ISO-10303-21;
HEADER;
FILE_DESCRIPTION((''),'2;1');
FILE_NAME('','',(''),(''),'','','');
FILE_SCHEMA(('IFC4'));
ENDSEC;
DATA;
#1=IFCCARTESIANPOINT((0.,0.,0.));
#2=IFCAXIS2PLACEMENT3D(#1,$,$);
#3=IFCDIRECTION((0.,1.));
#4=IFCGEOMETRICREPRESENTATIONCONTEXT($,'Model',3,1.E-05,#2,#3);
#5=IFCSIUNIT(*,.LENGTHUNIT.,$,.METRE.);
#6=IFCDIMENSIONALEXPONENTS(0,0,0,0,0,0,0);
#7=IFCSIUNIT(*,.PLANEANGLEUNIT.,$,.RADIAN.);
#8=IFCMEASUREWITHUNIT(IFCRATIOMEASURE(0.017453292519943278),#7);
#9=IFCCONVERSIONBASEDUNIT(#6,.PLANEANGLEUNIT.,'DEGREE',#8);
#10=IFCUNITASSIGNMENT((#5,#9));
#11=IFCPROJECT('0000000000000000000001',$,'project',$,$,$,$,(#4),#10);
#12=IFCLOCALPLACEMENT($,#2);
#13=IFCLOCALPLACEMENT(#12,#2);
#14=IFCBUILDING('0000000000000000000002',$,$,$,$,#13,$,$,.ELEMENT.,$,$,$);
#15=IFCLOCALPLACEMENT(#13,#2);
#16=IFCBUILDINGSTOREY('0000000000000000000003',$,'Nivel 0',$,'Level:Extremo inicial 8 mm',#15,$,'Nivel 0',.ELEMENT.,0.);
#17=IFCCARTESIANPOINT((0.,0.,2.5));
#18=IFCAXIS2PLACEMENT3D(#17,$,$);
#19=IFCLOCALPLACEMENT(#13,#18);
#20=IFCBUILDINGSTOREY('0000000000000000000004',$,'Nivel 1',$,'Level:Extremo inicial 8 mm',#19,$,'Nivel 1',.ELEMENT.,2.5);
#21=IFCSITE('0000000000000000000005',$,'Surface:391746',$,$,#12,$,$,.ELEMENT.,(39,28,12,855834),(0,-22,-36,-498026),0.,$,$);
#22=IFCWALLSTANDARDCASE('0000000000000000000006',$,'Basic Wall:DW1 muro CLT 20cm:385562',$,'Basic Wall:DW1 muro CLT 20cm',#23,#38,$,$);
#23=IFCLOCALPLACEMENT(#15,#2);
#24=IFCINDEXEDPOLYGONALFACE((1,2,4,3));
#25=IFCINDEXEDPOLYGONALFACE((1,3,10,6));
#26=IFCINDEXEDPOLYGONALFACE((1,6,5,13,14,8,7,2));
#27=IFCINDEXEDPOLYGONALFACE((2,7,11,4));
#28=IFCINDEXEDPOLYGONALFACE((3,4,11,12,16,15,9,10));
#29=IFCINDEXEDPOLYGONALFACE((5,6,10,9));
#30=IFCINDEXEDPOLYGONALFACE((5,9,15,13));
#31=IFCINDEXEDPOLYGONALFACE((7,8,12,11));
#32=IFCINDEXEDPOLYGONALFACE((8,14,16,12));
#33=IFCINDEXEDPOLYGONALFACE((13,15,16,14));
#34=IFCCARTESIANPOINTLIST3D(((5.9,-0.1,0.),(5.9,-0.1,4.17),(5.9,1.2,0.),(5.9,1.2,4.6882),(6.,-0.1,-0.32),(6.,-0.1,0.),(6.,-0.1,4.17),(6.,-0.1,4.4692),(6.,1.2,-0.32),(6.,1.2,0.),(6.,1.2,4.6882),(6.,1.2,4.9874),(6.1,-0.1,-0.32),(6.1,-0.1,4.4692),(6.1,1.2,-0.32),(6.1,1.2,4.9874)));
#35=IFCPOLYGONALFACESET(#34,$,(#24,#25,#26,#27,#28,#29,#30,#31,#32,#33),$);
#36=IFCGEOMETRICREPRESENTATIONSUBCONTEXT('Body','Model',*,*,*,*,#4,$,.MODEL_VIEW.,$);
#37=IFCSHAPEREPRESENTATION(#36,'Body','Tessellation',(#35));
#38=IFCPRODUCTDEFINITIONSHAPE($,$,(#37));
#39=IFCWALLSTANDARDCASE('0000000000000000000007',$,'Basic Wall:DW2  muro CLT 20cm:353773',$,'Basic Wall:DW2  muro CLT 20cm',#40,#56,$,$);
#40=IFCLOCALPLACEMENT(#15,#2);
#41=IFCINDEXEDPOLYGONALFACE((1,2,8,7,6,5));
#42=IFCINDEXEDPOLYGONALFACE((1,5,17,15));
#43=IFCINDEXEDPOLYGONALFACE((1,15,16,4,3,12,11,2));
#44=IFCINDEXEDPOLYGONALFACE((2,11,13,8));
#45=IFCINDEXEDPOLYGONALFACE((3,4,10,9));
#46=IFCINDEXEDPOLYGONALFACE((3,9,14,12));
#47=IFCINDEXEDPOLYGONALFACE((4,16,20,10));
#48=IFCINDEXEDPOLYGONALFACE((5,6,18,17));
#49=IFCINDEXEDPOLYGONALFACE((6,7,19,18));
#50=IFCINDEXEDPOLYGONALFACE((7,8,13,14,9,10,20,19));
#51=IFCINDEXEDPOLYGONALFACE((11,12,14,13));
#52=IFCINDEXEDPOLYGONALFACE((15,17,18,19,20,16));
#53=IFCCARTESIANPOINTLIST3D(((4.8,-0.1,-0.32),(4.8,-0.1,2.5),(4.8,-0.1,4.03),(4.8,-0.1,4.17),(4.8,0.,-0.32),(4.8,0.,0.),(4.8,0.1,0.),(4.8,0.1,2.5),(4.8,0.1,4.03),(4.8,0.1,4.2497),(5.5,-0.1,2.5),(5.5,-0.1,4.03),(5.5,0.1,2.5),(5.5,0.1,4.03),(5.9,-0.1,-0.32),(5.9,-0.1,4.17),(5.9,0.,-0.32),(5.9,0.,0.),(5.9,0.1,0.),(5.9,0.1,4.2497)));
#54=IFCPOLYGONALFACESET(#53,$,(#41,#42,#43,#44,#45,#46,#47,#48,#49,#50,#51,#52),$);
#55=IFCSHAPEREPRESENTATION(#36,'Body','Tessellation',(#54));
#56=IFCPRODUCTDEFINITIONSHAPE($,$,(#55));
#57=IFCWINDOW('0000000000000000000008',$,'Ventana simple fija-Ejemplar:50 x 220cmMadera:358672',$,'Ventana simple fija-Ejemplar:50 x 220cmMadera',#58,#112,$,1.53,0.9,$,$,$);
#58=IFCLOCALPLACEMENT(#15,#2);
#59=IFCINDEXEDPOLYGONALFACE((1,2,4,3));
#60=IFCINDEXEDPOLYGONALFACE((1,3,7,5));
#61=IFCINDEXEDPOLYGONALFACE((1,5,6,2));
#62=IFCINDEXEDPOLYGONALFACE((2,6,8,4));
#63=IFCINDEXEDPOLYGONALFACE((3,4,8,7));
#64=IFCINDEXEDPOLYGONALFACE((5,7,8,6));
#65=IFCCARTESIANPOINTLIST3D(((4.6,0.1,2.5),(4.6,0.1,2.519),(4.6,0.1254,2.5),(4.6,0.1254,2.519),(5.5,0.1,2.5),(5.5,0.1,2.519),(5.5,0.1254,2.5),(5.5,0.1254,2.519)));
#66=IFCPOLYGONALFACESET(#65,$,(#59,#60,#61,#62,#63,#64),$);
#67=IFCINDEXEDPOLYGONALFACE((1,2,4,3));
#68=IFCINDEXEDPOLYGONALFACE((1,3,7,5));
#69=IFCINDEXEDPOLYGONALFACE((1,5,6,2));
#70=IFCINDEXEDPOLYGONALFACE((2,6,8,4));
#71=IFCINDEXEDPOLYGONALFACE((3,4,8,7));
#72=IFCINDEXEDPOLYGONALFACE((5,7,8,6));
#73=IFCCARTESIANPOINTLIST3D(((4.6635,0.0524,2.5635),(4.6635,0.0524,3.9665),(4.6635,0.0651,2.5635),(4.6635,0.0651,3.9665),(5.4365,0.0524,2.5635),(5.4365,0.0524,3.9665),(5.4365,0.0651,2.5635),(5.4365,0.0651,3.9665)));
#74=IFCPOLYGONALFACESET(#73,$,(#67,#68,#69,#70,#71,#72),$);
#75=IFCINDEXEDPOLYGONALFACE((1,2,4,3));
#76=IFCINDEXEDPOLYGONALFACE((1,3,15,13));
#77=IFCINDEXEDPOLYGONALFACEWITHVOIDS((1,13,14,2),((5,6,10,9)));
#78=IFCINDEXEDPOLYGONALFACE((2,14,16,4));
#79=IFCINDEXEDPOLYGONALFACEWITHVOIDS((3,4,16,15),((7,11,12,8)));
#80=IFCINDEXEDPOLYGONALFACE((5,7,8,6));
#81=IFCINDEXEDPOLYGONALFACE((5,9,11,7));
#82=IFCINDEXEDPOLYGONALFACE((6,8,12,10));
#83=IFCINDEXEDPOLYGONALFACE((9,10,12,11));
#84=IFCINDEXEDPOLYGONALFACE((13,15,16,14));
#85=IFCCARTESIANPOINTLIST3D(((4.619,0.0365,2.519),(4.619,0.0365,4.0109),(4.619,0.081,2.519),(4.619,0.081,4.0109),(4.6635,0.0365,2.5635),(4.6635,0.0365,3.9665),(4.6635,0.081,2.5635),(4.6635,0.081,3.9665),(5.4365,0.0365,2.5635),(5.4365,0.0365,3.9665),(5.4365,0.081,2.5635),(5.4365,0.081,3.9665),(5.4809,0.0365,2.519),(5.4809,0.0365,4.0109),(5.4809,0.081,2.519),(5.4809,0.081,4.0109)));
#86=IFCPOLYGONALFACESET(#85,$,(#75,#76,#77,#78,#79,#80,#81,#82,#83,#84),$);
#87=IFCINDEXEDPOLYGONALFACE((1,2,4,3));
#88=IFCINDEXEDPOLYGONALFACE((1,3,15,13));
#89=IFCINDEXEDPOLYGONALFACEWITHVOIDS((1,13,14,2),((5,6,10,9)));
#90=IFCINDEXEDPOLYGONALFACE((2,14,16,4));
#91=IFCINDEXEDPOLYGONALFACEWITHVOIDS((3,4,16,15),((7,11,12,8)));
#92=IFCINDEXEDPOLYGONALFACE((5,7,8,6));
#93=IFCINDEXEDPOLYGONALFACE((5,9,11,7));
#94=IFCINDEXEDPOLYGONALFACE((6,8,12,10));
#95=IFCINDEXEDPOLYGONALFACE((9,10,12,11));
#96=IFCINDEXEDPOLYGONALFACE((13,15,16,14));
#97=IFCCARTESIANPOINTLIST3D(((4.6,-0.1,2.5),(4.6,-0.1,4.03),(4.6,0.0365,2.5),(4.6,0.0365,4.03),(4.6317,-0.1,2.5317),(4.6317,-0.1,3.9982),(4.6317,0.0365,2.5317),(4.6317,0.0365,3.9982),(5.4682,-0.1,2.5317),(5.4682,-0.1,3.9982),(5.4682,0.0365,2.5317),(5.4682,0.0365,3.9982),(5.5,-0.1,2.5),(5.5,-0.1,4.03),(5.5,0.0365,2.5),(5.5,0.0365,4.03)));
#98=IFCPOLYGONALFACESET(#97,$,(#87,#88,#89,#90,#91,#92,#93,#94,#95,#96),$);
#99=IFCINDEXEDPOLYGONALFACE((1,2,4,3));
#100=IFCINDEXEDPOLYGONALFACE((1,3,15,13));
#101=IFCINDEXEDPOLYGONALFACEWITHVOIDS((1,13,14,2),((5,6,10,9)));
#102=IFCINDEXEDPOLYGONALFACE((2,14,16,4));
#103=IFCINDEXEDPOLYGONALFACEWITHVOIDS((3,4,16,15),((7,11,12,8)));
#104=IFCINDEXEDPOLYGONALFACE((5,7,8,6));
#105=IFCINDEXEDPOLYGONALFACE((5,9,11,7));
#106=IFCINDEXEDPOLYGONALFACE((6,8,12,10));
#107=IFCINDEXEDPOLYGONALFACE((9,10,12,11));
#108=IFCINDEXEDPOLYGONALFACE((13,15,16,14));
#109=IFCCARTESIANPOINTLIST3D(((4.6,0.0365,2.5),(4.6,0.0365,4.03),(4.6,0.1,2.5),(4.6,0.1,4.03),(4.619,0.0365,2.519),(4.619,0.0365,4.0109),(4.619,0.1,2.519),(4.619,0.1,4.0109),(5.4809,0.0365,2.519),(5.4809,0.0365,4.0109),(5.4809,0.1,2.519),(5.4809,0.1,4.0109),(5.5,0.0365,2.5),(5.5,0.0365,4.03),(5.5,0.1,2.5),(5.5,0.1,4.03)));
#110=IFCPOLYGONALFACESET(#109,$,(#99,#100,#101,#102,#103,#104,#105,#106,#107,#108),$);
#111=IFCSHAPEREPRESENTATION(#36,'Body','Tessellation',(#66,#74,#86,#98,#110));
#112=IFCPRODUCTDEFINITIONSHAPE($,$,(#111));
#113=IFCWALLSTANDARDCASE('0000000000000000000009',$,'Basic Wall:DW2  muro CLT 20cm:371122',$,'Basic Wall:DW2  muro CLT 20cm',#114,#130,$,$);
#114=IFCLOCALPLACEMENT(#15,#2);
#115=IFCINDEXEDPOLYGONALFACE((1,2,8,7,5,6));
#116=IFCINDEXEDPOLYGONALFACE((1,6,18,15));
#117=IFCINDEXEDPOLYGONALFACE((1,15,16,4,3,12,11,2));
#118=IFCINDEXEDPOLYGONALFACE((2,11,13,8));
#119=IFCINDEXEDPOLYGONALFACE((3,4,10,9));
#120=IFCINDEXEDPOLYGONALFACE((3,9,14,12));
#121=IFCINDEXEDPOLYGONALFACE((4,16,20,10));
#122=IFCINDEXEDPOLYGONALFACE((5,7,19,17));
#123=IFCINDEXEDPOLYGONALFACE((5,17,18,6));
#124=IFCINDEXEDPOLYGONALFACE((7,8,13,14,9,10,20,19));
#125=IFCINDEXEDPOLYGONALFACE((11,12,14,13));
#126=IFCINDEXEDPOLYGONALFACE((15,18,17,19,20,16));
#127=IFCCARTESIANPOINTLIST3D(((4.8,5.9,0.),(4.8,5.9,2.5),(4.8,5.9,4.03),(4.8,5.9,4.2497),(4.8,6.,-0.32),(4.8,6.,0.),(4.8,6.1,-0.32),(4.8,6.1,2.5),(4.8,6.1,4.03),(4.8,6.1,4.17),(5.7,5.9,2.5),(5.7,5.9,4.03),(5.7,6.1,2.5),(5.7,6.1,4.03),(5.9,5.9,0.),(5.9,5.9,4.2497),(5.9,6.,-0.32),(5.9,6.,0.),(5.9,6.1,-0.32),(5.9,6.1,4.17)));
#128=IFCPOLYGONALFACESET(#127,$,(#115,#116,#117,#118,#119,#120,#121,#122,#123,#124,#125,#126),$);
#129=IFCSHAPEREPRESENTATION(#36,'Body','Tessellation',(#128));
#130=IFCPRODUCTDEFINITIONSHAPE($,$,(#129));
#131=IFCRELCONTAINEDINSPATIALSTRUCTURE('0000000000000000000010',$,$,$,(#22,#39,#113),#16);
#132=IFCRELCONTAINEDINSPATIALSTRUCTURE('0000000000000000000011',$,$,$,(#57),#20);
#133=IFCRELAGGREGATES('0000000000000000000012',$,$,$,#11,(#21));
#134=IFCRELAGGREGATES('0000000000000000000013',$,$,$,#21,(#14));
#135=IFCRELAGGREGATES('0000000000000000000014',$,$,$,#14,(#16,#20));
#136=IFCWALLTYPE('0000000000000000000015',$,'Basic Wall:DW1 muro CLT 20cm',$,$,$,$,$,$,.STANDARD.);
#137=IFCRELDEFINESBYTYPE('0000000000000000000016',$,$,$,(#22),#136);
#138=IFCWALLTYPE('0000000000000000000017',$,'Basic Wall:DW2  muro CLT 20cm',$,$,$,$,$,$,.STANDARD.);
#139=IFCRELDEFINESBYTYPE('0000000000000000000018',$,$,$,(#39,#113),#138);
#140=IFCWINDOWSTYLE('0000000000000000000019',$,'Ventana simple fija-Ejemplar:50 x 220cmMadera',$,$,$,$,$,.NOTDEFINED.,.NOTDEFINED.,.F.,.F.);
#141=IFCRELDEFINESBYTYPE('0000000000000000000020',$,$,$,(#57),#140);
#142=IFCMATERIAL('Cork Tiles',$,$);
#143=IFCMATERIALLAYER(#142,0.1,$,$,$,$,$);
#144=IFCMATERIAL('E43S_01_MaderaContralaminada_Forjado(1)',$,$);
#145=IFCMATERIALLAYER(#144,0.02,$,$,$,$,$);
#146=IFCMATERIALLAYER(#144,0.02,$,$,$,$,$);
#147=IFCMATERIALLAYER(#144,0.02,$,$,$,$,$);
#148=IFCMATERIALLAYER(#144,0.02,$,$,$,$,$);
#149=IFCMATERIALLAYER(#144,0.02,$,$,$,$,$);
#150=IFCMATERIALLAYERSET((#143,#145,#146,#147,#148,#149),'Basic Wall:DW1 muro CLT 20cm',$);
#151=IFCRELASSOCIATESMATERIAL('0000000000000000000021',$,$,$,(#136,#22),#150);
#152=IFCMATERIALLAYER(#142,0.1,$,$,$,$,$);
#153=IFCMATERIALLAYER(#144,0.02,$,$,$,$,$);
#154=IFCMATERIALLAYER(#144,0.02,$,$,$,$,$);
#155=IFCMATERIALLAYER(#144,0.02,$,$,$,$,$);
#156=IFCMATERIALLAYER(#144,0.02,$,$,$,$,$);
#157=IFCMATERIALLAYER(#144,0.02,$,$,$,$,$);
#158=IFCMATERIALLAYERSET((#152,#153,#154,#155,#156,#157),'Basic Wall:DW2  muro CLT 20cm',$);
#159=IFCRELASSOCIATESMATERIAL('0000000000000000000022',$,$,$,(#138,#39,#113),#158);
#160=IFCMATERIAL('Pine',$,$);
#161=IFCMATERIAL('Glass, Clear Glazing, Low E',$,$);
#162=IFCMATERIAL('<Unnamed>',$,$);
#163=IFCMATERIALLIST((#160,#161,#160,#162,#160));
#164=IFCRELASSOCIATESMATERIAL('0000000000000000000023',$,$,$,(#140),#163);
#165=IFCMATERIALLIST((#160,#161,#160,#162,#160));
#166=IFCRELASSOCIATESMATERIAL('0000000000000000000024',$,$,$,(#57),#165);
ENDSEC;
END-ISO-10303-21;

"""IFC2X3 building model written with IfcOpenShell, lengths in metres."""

from ifc_helpers import new_model, entity, si_unit, converted_unit, direction, frame, frame_2d, origin, origin_2d_with_axis, place, context, subcontext, project, spatial, polyline, rectangle, outline, extrude, clip, bounded_halfspace, source, transform, mapped, material, material_list, layer, layer_set, layer_usage, type_object, type_shapes, element, fill, save


model = new_model("IFC2X3")

# Units and contexts
model_context = context("Model", 3, precision=1e-05, world=origin(), true_north=direction((0.0, 1.0)))
body_context = subcontext(model_context, "Body", "Model", "MODEL_VIEW")
ifc_project = project(units=[si_unit("LENGTHUNIT", "METRE"), converted_unit("PLANEANGLEUNIT", "DEGREE", entity("IfcRatioMeasure", 0.017453292519943278), si_unit("PLANEANGLEUNIT", "RADIAN"), dimensions=[0, 0, 0, 0, 0, 0, 0])], contexts=[model_context])

# Site, building, storey
site_placement = place(None, origin())
site = spatial("IfcSite", under=ifc_project, at=site_placement, Name="Surface:391746", CompositionType="ELEMENT", RefLatitude=(39, 28, 12, 855834), RefLongitude=(0, -22, -36, -498026), RefElevation=0.0)
building_placement = place(site_placement, origin())
building = spatial("IfcBuilding", under=site, at=building_placement, CompositionType="ELEMENT")
storey_1_placement = place(building_placement, origin())
storey_1 = spatial("IfcBuildingStorey", under=building, at=storey_1_placement, Name="Nivel 0", ObjectType="Level:Extremo inicial 8 mm", LongName="Nivel 0", CompositionType="ELEMENT", Elevation=0.0)

# Shared definitions
ifc_material_1 = material(Name="E43S_01_MaderaContralaminada_Forjado(1)")

# Wall
ifc_material_2 = material(Name="Cork Tiles")
ifc_layer_1 = layer(ifc_material_2, 0.1)
ifc_layer_2 = layer(ifc_material_1, 0.02)
ifc_layer_3 = layer(ifc_material_1, 0.02)
ifc_layer_4 = layer(ifc_material_1, 0.02)
ifc_layer_5 = layer(ifc_material_1, 0.02)
ifc_layer_6 = layer(ifc_material_1, 0.02)
ifc_layer_set_1 = layer_set([ifc_layer_1, ifc_layer_2, ifc_layer_3, ifc_layer_4, ifc_layer_5, ifc_layer_6], Name="Basic Wall:DW1 muro CLT 20cm")
wall_type_1 = type_object("IfcWallType", Name="Basic Wall:DW1 muro CLT 20cm", PredefinedType="STANDARD", material=ifc_layer_set_1)
ifc_layer_usage_1 = layer_usage(ifc_layer_set_1, "AXIS2", "NEGATIVE", 0.1)
wall_1_placement = place(storey_1_placement, frame((6.0, 1.2, -0.32), z_axis=(0.0, 0.0, 1.0), x_axis=(0.0, -1.0, 0.0)))
element("IfcWallStandardCase", 1, at=wall_1_placement, inside=storey_1, type_object=wall_type_1, material=ifc_layer_usage_1, Name="Basic Wall:DW1 muro CLT 20cm:385562", ObjectType="Basic Wall:DW1 muro CLT 20cm", context=body_context, shape_type="Clipping", body=[
    clip(clip(clip(extrude(rectangle(XDim=1.3, YDim=0.2, at=frame_2d((0.65, 0.0), x_axis=(-1.0, 0.0))), origin(), (0.0, 0.0, 1.0), 5.3074), bounded_halfspace(frame((0.0, -0.1, 5.0082), z_axis=(0.370288, 0.0, 0.928917), x_axis=(0.0, 1.0, 0.0)), False, frame((0.0, -0.1, 5.0082)), polyline([(0.0, 0.0), (1.1, 0.0), (1.3, 0.0), (1.3, 0.1), (0.0, 0.1), (0.0, 0.0)]))), bounded_halfspace(frame((1.3, 0.0, 4.7892), z_axis=(0.370288, 0.0, 0.928917), x_axis=(0.0, 1.0, 0.0)), False, frame((1.3, 0.0, 4.7892)), polyline([(0.0, 0.0), (0.0, 0.1), (-1.3, 0.1), (-1.3, 0.0), (0.0, 0.0)]))), bounded_halfspace(frame((1.3, -0.1, 0.32), z_axis=(0.0, 0.0, -1.0), x_axis=(0.0, 1.0, 0.0)), False, frame((1.3, -0.1, 0.32)), polyline([(0.0, 0.0), (0.0, 0.1), (-1.3, 0.1), (-1.3, 0.0), (-0.2, 0.0), (-0.1, 0.0), (0.0, 0.0)]))),
])

# Wall, openings
ifc_layer_7 = layer(ifc_material_2, 0.1)
ifc_layer_8 = layer(ifc_material_1, 0.02)
ifc_layer_9 = layer(ifc_material_1, 0.02)
ifc_layer_10 = layer(ifc_material_1, 0.02)
ifc_layer_11 = layer(ifc_material_1, 0.02)
ifc_layer_12 = layer(ifc_material_1, 0.02)
ifc_layer_set_2 = layer_set([ifc_layer_7, ifc_layer_8, ifc_layer_9, ifc_layer_10, ifc_layer_11, ifc_layer_12], Name="Basic Wall:DW2  muro CLT 20cm")
ifc_layer_usage_2 = layer_usage(ifc_layer_set_2, "AXIS2", "NEGATIVE", 0.1)
wall_type_2 = type_object("IfcWallType", Name="Basic Wall:DW2  muro CLT 20cm", PredefinedType="STANDARD", material=ifc_layer_set_2)
wall_2_placement = place(storey_1_placement, frame((5.9, 0.0, -0.32), z_axis=(0.0, 0.0, 1.0), x_axis=(-1.0, 0.0, 0.0)))
wall_2 = element("IfcWallStandardCase", 2, at=wall_2_placement, inside=storey_1, type_object=wall_type_2, material=ifc_layer_usage_2, Name="Basic Wall:DW2  muro CLT 20cm:353773", ObjectType="Basic Wall:DW2  muro CLT 20cm", context=body_context, shape_type="Clipping", body=[
    clip(clip(clip(extrude(rectangle(XDim=1.1, YDim=0.2, at=frame_2d((0.55, 0.0), x_axis=(-1.0, 0.0))), origin(), (0.0, 0.0, 1.0), 4.5697), bounded_halfspace(frame((0.0, -0.1, 4.5697), z_axis=(0.0, 0.370288, 0.928917), x_axis=(-1.0, 0.0, 0.0)), False, frame((0.0, -0.1, 4.5697)), polyline([(0.0, 0.0), (1.04, 0.0), (1.04, 0.2), (0.0, 0.2), (0.0, 0.0)]))), bounded_halfspace(frame((1.04, -0.1, 4.5697), z_axis=(0.0, 0.370288, 0.928917), x_axis=(-1.0, 0.0, 0.0)), False, frame((1.04, -0.1, 4.5697)), polyline([(0.0, 0.0), (0.06, 0.0), (0.06, 0.2), (0.0, 0.2), (0.0, 0.0)]))), bounded_halfspace(frame((1.1, -0.1, 0.32), z_axis=(0.0, 0.0, -1.0), x_axis=(0.0, 1.0, 0.0)), False, frame((1.1, -0.1, 0.32)), polyline([(0.0, 0.0), (0.0, 0.1), (-1.1, 0.1), (-1.1, 0.0), (0.0, 0.0)]))),
])
opening_1_placement = place(wall_2_placement, origin())
element("IfcOpeningElement", 3, at=opening_1_placement, cuts=wall_2, ObjectType="Opening", context=body_context, shape_type="SweptSolid", body=[
    extrude(rectangle(XDim=2.1, YDim=1.4, at=origin_2d_with_axis()), frame((4.7, -1.424, 1.37), z_axis=(0.0, 1.0, 0.0), x_axis=(0.0, 0.0, -1.0)), (0.0, 0.0, 1.0), 3.048),
])
opening_2_placement = place(wall_2_placement, frame((1.3, 0.1, 2.82)))
opening_2 = element("IfcOpeningElement", 4, at=opening_2_placement, cuts=wall_2, ObjectType="Opening", context=body_context, shape_type="SweptSolid", body=[
    extrude(rectangle(XDim=1.53, YDim=0.9, at=frame_2d((0.765, 0.45), x_axis=(-1.0, 0.0))), frame((0.0, 0.0, 0.0), z_axis=(0.0, -1.0, 0.0), x_axis=(0.0, 0.0, 1.0)), (0.0, 0.0, 1.0), 0.2),
])

# Shared definitions
storey_2_placement = place(building_placement, frame((0.0, 0.0, 2.5)))
storey_2 = spatial("IfcBuildingStorey", under=building, at=storey_2_placement, Name="Nivel 1", ObjectType="Level:Extremo inicial 8 mm", LongName="Nivel 1", CompositionType="ELEMENT", Elevation=2.5)

# Window
ifc_material_3 = material(Name="Pine")
ifc_material_4 = material(Name="Glass, Clear Glazing, Low E")
ifc_material_5 = material(Name="<Unnamed>")
ifc_material_list_1 = material_list([ifc_material_3, ifc_material_4, ifc_material_3, ifc_material_5, ifc_material_3])
ifc_material_list_2 = material_list([ifc_material_3, ifc_material_4, ifc_material_3, ifc_material_5, ifc_material_3])
window_style = type_object("IfcWindowStyle", Name="Ventana simple fija-Ejemplar:50 x 220cmMadera", ConstructionType="NOTDEFINED", OperationType="NOTDEFINED", ParameterTakesPrecedence=False, Sizeable=False, material=ifc_material_list_2)
shared_shape_1 = source(origin(), body_context, "Body", "SweptSolid", [
    extrude(rectangle(XDim=0.9, YDim=0.0254, at=origin_2d_with_axis()), frame((0.5262, 0.2127, 0.0), z_axis=(0.0, 0.0, 1.0), x_axis=(-1.0, 0.0, 0.0)), (0.0, 0.0, 1.0), 0.019),
    extrude(rectangle(XDim=0.773, YDim=0.0127, at=frame_2d((0.0, 0.0), x_axis=(1.0, 0.0))), frame((0.5262, 0.1588, 0.0635)), (0.0, 0.0, 1.0), 1.403),
    extrude(outline(polyline([(-0.431, -0.7459), (0.431, -0.7459), (0.431, 0.7459), (-0.431, 0.7459), (-0.431, -0.7459)]), holes=[polyline([(-0.3865, -0.7015), (-0.3865, 0.7015), (0.3865, 0.7015), (0.3865, -0.7015), (-0.3865, -0.7015)])]), frame((0.5262, 0.181, 0.765), z_axis=(0.0, -1.0, 0.0), x_axis=(-1.0, 0.0, 0.0)), (0.0, 0.0, 1.0), 0.0444),
    extrude(outline(polyline([(-0.45, -0.765), (0.45, -0.765), (0.45, 0.765), (-0.45, 0.765), (-0.45, -0.765)]), holes=[polyline([(-0.4183, -0.7332), (-0.4183, 0.7332), (0.4183, 0.7332), (0.4183, -0.7332), (-0.4183, -0.7332)])]), frame((0.5262, 0.1365, 0.765), z_axis=(0.0, -1.0, 0.0), x_axis=(-1.0, 0.0, 0.0)), (0.0, 0.0, 1.0), 0.1365),
    extrude(outline(polyline([(-0.765, -0.45), (0.765, -0.45), (0.765, 0.45), (-0.765, 0.45), (-0.765, -0.45)]), holes=[polyline([(-0.7459, -0.431), (-0.7459, 0.431), (0.7459, 0.431), (0.7459, -0.431), (-0.7459, -0.431)])]), frame((0.5262, 0.2, 0.765), z_axis=(0.0, -1.0, 0.0), x_axis=(0.0, 0.0, -1.0)), (0.0, 0.0, 1.0), 0.0635),
])
type_shapes(window_style, [shared_shape_1])
window_placement = place(opening_2_placement, frame((0.0762, 0.0, 0.0), z_axis=(0.0, 0.0, 1.0), x_axis=(-1.0, 0.0, 0.0)))
window = element("IfcWindow", 5, at=window_placement, inside=storey_2, type_object=window_style, material=ifc_material_list_1, Name="Ventana simple fija-Ejemplar:50 x 220cmMadera:358672", ObjectType="Ventana simple fija-Ejemplar:50 x 220cmMadera", OverallHeight=1.53, OverallWidth=0.9, context=body_context, shape_type="MappedRepresentation", body=[
    mapped(shared_shape_1, transform((0.0, 0.0, 0.0), scale=1.0)),
])
fill(opening_2, window)

# Wall, openings
ifc_layer_usage_3 = layer_usage(ifc_layer_set_2, "AXIS2", "NEGATIVE", 0.1)
wall_3_placement = place(storey_1_placement, frame((4.8, 6.0, -0.32)))
wall_3 = element("IfcWallStandardCase", 6, at=wall_3_placement, inside=storey_1, type_object=wall_type_2, material=ifc_layer_usage_3, Name="Basic Wall:DW2  muro CLT 20cm:371122", ObjectType="Basic Wall:DW2  muro CLT 20cm", context=body_context, shape_type="Clipping", body=[
    clip(clip(clip(extrude(rectangle(XDim=1.1, YDim=0.2, at=frame_2d((0.55, 0.0), x_axis=(-1.0, 0.0))), origin(), (0.0, 0.0, 1.0), 4.5697), bounded_halfspace(frame((0.0, -0.1, 4.5697), z_axis=(0.0, 0.370288, 0.928917), x_axis=(-1.0, 0.0, 0.0)), False, frame((0.0, -0.1, 4.5697)), polyline([(0.0, 0.0), (0.06, 0.0), (0.06, 0.2), (0.0, 0.2), (0.0, 0.0)]))), bounded_halfspace(frame((1.1, -0.1, 4.5697), z_axis=(0.0, 0.370288, 0.928917), x_axis=(-1.0, 0.0, 0.0)), False, frame((1.1, -0.1, 4.5697)), polyline([(0.0, 0.0), (0.0, 0.2), (-1.04, 0.2), (-1.04, 0.0), (0.0, 0.0)]))), bounded_halfspace(frame((1.1, -0.1, 0.32), z_axis=(0.0, 0.0, -1.0), x_axis=(0.0, 1.0, 0.0)), False, frame((1.1, -0.1, 0.32)), polyline([(0.0, 0.0), (0.0, 0.1), (-1.1, 0.1), (-1.1, 0.0), (0.0, 0.0)]))),
])
opening_3_placement = place(wall_3_placement, origin())
element("IfcOpeningElement", 7, at=opening_3_placement, cuts=wall_3, ObjectType="Opening", context=body_context, shape_type="SweptSolid", body=[
    extrude(rectangle(XDim=1.53, YDim=0.9, at=frame_2d((0.0, 0.0), x_axis=(1.0, 0.0))), frame((0.45, -1.378, 3.585), z_axis=(0.0, 1.0, 0.0), x_axis=(0.0, 0.0, -1.0)), (0.0, 0.0, 1.0), 3.048),
])
opening_4_placement = place(wall_3_placement, origin())
element("IfcOpeningElement", 8, at=opening_4_placement, cuts=wall_3, ObjectType="Opening", context=body_context, shape_type="SweptSolid", body=[
    extrude(rectangle(XDim=2.1, YDim=0.8, at=frame_2d((0.0, 0.0), x_axis=(1.0, 0.0))), frame((-3.9, -1.424, 1.37), z_axis=(0.0, 1.0, 0.0), x_axis=(0.0, 0.0, -1.0)), (0.0, 0.0, 1.0), 3.048),
])

save(model, "model.ifc")
